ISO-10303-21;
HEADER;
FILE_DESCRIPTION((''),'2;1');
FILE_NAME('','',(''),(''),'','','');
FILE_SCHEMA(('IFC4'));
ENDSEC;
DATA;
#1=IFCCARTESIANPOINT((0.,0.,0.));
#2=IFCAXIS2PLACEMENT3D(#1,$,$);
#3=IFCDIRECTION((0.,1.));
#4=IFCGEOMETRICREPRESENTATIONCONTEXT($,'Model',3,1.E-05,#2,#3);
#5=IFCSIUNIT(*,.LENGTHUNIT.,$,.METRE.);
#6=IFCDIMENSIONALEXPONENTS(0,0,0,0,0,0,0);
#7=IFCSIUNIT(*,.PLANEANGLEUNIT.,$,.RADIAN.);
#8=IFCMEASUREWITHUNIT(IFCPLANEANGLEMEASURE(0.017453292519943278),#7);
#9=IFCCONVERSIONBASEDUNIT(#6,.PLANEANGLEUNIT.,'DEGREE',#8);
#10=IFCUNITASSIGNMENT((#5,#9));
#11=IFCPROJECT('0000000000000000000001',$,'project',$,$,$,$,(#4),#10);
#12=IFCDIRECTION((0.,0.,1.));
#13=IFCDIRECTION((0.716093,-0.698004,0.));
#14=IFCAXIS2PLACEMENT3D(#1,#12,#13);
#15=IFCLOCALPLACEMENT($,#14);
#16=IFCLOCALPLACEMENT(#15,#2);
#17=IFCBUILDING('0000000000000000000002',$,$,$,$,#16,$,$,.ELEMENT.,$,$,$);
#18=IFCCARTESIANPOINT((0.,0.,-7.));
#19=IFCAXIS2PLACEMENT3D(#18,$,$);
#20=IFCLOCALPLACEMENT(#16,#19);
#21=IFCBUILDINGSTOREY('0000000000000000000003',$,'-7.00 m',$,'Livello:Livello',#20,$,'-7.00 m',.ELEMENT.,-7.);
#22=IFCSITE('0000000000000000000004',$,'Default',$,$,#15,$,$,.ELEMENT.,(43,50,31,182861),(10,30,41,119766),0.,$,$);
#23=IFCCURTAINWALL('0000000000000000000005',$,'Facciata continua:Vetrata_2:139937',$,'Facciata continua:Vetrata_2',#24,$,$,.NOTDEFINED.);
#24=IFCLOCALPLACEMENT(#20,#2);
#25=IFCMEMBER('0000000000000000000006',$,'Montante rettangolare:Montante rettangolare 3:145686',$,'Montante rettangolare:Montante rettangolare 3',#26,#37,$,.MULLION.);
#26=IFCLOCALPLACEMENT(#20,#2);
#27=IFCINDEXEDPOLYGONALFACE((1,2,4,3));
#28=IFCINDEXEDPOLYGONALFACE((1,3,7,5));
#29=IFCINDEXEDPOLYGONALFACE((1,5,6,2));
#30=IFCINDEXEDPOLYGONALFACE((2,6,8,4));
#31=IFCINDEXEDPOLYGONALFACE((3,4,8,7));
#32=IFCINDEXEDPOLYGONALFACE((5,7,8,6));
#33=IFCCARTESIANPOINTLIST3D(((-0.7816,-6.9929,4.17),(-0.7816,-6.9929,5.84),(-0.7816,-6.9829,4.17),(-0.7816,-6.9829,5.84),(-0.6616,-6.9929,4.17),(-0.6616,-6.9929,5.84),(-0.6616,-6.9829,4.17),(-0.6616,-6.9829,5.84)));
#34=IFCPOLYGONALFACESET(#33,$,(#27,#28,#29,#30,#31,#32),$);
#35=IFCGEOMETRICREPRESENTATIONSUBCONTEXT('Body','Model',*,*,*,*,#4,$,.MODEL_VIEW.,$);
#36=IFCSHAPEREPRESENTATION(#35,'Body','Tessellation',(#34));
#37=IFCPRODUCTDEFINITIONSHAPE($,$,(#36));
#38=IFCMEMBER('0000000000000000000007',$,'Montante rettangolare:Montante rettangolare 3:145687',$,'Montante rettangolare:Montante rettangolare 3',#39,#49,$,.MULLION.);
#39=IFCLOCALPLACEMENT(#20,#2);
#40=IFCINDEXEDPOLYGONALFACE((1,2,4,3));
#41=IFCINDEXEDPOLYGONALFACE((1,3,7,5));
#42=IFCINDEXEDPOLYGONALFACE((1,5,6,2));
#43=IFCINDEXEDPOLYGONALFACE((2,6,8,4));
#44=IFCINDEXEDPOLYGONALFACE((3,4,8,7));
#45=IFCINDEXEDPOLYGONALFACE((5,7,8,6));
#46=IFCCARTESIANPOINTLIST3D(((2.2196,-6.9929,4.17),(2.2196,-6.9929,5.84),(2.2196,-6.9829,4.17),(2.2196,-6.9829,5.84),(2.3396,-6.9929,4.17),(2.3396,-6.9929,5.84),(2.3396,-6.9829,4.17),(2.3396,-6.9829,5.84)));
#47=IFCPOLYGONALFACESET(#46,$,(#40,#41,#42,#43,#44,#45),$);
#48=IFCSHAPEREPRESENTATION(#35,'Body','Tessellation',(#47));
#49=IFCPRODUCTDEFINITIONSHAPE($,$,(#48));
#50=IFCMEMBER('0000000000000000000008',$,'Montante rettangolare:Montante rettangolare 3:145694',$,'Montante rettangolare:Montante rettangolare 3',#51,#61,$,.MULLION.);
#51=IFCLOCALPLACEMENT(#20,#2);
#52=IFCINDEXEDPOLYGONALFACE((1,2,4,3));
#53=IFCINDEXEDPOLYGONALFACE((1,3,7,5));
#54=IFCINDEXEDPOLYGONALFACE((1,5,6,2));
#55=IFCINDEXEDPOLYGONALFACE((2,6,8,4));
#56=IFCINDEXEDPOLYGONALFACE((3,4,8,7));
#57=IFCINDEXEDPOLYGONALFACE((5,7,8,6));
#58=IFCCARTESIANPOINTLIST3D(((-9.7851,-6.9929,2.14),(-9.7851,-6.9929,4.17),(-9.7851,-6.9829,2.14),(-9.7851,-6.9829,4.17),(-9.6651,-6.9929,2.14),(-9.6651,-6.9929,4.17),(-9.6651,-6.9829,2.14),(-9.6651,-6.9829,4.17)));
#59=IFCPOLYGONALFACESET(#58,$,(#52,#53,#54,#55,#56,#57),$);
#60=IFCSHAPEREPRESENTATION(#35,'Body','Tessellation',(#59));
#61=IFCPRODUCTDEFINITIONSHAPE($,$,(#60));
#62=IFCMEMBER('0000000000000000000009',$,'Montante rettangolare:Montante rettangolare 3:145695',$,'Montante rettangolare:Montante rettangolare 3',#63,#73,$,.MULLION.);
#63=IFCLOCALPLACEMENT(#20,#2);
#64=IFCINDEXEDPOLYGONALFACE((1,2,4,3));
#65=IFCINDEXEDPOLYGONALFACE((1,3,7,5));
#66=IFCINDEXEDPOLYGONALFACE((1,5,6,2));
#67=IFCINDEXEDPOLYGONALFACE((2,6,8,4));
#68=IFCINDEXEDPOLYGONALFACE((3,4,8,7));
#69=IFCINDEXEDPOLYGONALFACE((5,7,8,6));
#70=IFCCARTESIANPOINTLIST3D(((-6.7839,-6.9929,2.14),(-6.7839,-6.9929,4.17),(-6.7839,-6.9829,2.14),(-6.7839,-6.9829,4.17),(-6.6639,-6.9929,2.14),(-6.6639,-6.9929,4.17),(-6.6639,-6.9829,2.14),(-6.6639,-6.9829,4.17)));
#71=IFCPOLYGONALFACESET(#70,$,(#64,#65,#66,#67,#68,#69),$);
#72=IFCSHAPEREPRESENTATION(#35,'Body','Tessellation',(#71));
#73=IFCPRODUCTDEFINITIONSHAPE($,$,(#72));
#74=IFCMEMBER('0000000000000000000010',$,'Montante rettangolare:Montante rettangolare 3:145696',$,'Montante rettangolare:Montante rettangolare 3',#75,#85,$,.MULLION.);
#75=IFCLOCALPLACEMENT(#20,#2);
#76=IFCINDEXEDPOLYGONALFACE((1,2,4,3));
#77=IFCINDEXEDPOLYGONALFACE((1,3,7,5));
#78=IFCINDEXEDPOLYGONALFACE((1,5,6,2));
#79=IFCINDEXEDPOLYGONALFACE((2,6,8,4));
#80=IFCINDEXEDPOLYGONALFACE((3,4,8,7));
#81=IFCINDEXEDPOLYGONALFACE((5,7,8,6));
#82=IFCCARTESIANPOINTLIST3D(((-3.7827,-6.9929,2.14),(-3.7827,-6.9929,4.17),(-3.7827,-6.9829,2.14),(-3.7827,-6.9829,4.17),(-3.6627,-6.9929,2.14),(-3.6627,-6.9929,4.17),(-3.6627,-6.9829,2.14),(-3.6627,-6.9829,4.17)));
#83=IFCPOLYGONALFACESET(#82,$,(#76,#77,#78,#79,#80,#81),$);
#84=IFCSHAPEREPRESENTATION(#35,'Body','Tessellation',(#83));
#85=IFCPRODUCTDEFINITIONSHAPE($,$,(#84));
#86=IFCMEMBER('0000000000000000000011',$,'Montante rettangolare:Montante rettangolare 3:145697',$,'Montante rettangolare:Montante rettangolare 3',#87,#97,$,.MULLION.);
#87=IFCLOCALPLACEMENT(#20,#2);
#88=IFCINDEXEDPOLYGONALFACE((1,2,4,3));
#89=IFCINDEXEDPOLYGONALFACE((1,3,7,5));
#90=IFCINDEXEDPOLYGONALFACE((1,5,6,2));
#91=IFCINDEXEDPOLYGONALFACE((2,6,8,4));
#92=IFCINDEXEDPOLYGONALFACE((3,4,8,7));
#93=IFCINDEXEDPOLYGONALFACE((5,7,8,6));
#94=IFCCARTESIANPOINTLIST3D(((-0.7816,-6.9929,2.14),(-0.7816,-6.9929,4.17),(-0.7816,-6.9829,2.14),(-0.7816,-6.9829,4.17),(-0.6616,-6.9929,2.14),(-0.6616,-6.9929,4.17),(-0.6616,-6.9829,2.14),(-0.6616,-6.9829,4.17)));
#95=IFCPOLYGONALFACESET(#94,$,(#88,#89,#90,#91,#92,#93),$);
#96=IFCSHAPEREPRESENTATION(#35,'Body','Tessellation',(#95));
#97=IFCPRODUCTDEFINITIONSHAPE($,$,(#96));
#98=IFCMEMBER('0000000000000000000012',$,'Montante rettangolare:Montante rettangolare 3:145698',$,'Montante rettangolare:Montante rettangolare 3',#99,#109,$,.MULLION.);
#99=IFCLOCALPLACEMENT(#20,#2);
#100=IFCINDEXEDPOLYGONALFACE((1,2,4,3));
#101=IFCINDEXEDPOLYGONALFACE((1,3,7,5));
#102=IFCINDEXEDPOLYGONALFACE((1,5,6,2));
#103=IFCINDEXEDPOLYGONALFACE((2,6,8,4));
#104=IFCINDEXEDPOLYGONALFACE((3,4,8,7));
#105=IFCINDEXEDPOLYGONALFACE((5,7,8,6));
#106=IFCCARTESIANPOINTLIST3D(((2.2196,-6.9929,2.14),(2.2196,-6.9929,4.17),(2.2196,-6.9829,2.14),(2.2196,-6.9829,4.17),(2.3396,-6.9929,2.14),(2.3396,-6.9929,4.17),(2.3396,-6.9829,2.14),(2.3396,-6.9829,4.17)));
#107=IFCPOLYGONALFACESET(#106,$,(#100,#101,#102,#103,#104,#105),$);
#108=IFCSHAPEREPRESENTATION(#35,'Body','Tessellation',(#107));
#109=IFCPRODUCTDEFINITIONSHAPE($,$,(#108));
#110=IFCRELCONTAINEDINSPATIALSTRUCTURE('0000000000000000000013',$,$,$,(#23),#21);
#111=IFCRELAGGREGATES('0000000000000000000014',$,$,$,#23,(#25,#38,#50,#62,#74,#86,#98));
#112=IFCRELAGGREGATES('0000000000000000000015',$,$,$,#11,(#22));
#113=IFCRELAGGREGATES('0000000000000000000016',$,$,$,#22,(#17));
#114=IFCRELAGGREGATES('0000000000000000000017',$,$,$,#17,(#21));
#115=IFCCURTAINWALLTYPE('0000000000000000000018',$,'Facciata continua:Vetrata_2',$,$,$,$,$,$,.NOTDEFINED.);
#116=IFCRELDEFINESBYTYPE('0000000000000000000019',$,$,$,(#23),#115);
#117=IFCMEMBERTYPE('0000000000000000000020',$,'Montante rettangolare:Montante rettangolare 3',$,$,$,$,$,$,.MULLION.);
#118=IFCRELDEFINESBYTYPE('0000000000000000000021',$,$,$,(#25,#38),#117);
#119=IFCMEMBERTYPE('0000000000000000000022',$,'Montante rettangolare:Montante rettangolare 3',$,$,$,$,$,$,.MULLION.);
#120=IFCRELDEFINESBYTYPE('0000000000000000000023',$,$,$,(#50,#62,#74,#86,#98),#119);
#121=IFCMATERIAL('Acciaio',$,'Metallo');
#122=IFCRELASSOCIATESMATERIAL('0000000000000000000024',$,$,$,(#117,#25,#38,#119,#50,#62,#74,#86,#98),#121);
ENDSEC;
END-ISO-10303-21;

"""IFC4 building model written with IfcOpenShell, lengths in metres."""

from ifc_helpers import new_model, entity, si_unit, converted_unit, direction, frame, origin, place, context, subcontext, project, spatial, indexed_curve, outline, extrude, source, transform, mapped, material, type_object, type_shapes, element, aggregate, save


model = new_model("IFC4")

# Units and contexts
model_context = context("Model", 3, precision=1e-05, world=origin(), true_north=direction((0.0, 1.0)))
body_context = subcontext(model_context, "Body", "Model", "MODEL_VIEW")
ifc_project = project(units=[si_unit("LENGTHUNIT", "METRE"), converted_unit("PLANEANGLEUNIT", "DEGREE", entity("IfcPlaneAngleMeasure", 0.017453292519943278), si_unit("PLANEANGLEUNIT", "RADIAN"), dimensions=[0, 0, 0, 0, 0, 0, 0])], contexts=[model_context])

# Site, building, storey
site_placement = place(None, frame((0.0, 0.0, 0.0), z_axis=(0.0, 0.0, 1.0), x_axis=(0.716093, -0.698004, 0.0)))
site = spatial("IfcSite", under=ifc_project, at=site_placement, Name="Default", CompositionType="ELEMENT", RefLatitude=(43, 50, 31, 182861), RefLongitude=(10, 30, 41, 119766), RefElevation=0.0)
building_placement = place(site_placement, origin())
building = spatial("IfcBuilding", under=site, at=building_placement, CompositionType="ELEMENT")
storey_placement = place(building_placement, frame((0.0, 0.0, -7.0)))
storey = spatial("IfcBuildingStorey", under=building, at=storey_placement, Name="-7.00 m", ObjectType="Livello:Livello", LongName="-7.00 m", CompositionType="ELEMENT", Elevation=-7.0)

# Curtain wall, members
curtain_wall_type = type_object("IfcCurtainWallType", Name="Facciata continua:Vetrata_2", PredefinedType="NOTDEFINED")
curtain_wall_placement = place(storey_placement, frame((0.0, 0.0, 7.0)))
curtain_wall = element("IfcCurtainWall", 1, at=curtain_wall_placement, inside=storey, type_object=curtain_wall_type, Name="Facciata continua:Vetrata_2:139937", ObjectType="Facciata continua:Vetrata_2", PredefinedType="NOTDEFINED")
ifc_material = material(Name="Acciaio", Category="Metallo")
member_type_1 = type_object("IfcMemberType", Name="Montante rettangolare:Montante rettangolare 3", PredefinedType="MULLION", material=ifc_material)
shared_shape_1 = source(origin(), body_context, "Body", "SweptSolid", [
    extrude(outline(indexed_curve([(-0.06, -0.005), (0.06, -0.005), (0.06, 0.005), (-0.06, 0.005), (-0.06, -0.005)], self_intersect=False)), frame((0.0, 0.01, -1.67), z_axis=(0.0, 0.0, 1.0), x_axis=(-1.0, 0.0, 0.0)), (0.0, 0.0, 1.0), 1.67),
])
type_shapes(member_type_1, [shared_shape_1])
member_1_placement = place(curtain_wall_placement, frame((-0.7216, -6.9779, -2.83), z_axis=(0.0, 0.0, -1.0), x_axis=(1.0, 0.0, 0.0)))
member_1 = element("IfcMember", 2, at=member_1_placement, type_object=member_type_1, material=ifc_material, Name="Montante rettangolare:Montante rettangolare 3:145686", ObjectType="Montante rettangolare:Montante rettangolare 3", PredefinedType="MULLION", context=body_context, shape_type="MappedRepresentation", body=[
    mapped(shared_shape_1, transform((0.0, 0.0, 0.0), scale=1.0)),
])
member_2_placement = place(curtain_wall_placement, frame((2.2796, -6.9779, -2.83), z_axis=(0.0, 0.0, -1.0), x_axis=(1.0, 0.0, 0.0)))
member_2 = element("IfcMember", 3, at=member_2_placement, type_object=member_type_1, material=ifc_material, Name="Montante rettangolare:Montante rettangolare 3:145687", ObjectType="Montante rettangolare:Montante rettangolare 3", PredefinedType="MULLION", context=body_context, shape_type="MappedRepresentation", body=[
    mapped(shared_shape_1, transform((0.0, 0.0, 0.0), scale=1.0)),
])
member_type_2 = type_object("IfcMemberType", Name="Montante rettangolare:Montante rettangolare 3", PredefinedType="MULLION", material=ifc_material)
shared_shape_2 = source(origin(), body_context, "Body", "SweptSolid", [
    extrude(outline(indexed_curve([(-0.06, -0.005), (0.06, -0.005), (0.06, 0.005), (-0.06, 0.005), (-0.06, -0.005)], self_intersect=False)), frame((0.0, 0.01, -2.03), z_axis=(0.0, 0.0, 1.0), x_axis=(-1.0, 0.0, 0.0)), (0.0, 0.0, 1.0), 2.03),
])
type_shapes(member_type_2, [shared_shape_2])
member_3_placement = place(curtain_wall_placement, frame((-9.7251, -6.9779, -4.86), z_axis=(0.0, 0.0, -1.0), x_axis=(1.0, 0.0, 0.0)))
member_3 = element("IfcMember", 4, at=member_3_placement, type_object=member_type_2, material=ifc_material, Name="Montante rettangolare:Montante rettangolare 3:145694", ObjectType="Montante rettangolare:Montante rettangolare 3", PredefinedType="MULLION", context=body_context, shape_type="MappedRepresentation", body=[
    mapped(shared_shape_2, transform((0.0, 0.0, 0.0), scale=1.0)),
])
member_4_placement = place(curtain_wall_placement, frame((-6.7239, -6.9779, -4.86), z_axis=(0.0, 0.0, -1.0), x_axis=(1.0, 0.0, 0.0)))
member_4 = element("IfcMember", 5, at=member_4_placement, type_object=member_type_2, material=ifc_material, Name="Montante rettangolare:Montante rettangolare 3:145695", ObjectType="Montante rettangolare:Montante rettangolare 3", PredefinedType="MULLION", context=body_context, shape_type="MappedRepresentation", body=[
    mapped(shared_shape_2, transform((0.0, 0.0, 0.0), scale=1.0)),
])
member_5_placement = place(curtain_wall_placement, frame((-3.7227, -6.9779, -4.86), z_axis=(0.0, 0.0, -1.0), x_axis=(1.0, 0.0, 0.0)))
member_5 = element("IfcMember", 6, at=member_5_placement, type_object=member_type_2, material=ifc_material, Name="Montante rettangolare:Montante rettangolare 3:145696", ObjectType="Montante rettangolare:Montante rettangolare 3", PredefinedType="MULLION", context=body_context, shape_type="MappedRepresentation", body=[
    mapped(shared_shape_2, transform((0.0, 0.0, 0.0), scale=1.0)),
])
member_6_placement = place(curtain_wall_placement, frame((-0.7216, -6.9779, -4.86), z_axis=(0.0, 0.0, -1.0), x_axis=(1.0, 0.0, 0.0)))
member_6 = element("IfcMember", 7, at=member_6_placement, type_object=member_type_2, material=ifc_material, Name="Montante rettangolare:Montante rettangolare 3:145697", ObjectType="Montante rettangolare:Montante rettangolare 3", PredefinedType="MULLION", context=body_context, shape_type="MappedRepresentation", body=[
    mapped(shared_shape_2, transform((0.0, 0.0, 0.0), scale=1.0)),
])
member_7_placement = place(curtain_wall_placement, frame((2.2796, -6.9779, -4.86), z_axis=(0.0, 0.0, -1.0), x_axis=(1.0, 0.0, 0.0)))
member_7 = element("IfcMember", 8, at=member_7_placement, type_object=member_type_2, material=ifc_material, Name="Montante rettangolare:Montante rettangolare 3:145698", ObjectType="Montante rettangolare:Montante rettangolare 3", PredefinedType="MULLION", context=body_context, shape_type="MappedRepresentation", body=[
    mapped(shared_shape_2, transform((0.0, 0.0, 0.0), scale=1.0)),
])
aggregate(curtain_wall, [member_1, member_2, member_3, member_4, member_5, member_6, member_7])

save(model, "model.ifc")
